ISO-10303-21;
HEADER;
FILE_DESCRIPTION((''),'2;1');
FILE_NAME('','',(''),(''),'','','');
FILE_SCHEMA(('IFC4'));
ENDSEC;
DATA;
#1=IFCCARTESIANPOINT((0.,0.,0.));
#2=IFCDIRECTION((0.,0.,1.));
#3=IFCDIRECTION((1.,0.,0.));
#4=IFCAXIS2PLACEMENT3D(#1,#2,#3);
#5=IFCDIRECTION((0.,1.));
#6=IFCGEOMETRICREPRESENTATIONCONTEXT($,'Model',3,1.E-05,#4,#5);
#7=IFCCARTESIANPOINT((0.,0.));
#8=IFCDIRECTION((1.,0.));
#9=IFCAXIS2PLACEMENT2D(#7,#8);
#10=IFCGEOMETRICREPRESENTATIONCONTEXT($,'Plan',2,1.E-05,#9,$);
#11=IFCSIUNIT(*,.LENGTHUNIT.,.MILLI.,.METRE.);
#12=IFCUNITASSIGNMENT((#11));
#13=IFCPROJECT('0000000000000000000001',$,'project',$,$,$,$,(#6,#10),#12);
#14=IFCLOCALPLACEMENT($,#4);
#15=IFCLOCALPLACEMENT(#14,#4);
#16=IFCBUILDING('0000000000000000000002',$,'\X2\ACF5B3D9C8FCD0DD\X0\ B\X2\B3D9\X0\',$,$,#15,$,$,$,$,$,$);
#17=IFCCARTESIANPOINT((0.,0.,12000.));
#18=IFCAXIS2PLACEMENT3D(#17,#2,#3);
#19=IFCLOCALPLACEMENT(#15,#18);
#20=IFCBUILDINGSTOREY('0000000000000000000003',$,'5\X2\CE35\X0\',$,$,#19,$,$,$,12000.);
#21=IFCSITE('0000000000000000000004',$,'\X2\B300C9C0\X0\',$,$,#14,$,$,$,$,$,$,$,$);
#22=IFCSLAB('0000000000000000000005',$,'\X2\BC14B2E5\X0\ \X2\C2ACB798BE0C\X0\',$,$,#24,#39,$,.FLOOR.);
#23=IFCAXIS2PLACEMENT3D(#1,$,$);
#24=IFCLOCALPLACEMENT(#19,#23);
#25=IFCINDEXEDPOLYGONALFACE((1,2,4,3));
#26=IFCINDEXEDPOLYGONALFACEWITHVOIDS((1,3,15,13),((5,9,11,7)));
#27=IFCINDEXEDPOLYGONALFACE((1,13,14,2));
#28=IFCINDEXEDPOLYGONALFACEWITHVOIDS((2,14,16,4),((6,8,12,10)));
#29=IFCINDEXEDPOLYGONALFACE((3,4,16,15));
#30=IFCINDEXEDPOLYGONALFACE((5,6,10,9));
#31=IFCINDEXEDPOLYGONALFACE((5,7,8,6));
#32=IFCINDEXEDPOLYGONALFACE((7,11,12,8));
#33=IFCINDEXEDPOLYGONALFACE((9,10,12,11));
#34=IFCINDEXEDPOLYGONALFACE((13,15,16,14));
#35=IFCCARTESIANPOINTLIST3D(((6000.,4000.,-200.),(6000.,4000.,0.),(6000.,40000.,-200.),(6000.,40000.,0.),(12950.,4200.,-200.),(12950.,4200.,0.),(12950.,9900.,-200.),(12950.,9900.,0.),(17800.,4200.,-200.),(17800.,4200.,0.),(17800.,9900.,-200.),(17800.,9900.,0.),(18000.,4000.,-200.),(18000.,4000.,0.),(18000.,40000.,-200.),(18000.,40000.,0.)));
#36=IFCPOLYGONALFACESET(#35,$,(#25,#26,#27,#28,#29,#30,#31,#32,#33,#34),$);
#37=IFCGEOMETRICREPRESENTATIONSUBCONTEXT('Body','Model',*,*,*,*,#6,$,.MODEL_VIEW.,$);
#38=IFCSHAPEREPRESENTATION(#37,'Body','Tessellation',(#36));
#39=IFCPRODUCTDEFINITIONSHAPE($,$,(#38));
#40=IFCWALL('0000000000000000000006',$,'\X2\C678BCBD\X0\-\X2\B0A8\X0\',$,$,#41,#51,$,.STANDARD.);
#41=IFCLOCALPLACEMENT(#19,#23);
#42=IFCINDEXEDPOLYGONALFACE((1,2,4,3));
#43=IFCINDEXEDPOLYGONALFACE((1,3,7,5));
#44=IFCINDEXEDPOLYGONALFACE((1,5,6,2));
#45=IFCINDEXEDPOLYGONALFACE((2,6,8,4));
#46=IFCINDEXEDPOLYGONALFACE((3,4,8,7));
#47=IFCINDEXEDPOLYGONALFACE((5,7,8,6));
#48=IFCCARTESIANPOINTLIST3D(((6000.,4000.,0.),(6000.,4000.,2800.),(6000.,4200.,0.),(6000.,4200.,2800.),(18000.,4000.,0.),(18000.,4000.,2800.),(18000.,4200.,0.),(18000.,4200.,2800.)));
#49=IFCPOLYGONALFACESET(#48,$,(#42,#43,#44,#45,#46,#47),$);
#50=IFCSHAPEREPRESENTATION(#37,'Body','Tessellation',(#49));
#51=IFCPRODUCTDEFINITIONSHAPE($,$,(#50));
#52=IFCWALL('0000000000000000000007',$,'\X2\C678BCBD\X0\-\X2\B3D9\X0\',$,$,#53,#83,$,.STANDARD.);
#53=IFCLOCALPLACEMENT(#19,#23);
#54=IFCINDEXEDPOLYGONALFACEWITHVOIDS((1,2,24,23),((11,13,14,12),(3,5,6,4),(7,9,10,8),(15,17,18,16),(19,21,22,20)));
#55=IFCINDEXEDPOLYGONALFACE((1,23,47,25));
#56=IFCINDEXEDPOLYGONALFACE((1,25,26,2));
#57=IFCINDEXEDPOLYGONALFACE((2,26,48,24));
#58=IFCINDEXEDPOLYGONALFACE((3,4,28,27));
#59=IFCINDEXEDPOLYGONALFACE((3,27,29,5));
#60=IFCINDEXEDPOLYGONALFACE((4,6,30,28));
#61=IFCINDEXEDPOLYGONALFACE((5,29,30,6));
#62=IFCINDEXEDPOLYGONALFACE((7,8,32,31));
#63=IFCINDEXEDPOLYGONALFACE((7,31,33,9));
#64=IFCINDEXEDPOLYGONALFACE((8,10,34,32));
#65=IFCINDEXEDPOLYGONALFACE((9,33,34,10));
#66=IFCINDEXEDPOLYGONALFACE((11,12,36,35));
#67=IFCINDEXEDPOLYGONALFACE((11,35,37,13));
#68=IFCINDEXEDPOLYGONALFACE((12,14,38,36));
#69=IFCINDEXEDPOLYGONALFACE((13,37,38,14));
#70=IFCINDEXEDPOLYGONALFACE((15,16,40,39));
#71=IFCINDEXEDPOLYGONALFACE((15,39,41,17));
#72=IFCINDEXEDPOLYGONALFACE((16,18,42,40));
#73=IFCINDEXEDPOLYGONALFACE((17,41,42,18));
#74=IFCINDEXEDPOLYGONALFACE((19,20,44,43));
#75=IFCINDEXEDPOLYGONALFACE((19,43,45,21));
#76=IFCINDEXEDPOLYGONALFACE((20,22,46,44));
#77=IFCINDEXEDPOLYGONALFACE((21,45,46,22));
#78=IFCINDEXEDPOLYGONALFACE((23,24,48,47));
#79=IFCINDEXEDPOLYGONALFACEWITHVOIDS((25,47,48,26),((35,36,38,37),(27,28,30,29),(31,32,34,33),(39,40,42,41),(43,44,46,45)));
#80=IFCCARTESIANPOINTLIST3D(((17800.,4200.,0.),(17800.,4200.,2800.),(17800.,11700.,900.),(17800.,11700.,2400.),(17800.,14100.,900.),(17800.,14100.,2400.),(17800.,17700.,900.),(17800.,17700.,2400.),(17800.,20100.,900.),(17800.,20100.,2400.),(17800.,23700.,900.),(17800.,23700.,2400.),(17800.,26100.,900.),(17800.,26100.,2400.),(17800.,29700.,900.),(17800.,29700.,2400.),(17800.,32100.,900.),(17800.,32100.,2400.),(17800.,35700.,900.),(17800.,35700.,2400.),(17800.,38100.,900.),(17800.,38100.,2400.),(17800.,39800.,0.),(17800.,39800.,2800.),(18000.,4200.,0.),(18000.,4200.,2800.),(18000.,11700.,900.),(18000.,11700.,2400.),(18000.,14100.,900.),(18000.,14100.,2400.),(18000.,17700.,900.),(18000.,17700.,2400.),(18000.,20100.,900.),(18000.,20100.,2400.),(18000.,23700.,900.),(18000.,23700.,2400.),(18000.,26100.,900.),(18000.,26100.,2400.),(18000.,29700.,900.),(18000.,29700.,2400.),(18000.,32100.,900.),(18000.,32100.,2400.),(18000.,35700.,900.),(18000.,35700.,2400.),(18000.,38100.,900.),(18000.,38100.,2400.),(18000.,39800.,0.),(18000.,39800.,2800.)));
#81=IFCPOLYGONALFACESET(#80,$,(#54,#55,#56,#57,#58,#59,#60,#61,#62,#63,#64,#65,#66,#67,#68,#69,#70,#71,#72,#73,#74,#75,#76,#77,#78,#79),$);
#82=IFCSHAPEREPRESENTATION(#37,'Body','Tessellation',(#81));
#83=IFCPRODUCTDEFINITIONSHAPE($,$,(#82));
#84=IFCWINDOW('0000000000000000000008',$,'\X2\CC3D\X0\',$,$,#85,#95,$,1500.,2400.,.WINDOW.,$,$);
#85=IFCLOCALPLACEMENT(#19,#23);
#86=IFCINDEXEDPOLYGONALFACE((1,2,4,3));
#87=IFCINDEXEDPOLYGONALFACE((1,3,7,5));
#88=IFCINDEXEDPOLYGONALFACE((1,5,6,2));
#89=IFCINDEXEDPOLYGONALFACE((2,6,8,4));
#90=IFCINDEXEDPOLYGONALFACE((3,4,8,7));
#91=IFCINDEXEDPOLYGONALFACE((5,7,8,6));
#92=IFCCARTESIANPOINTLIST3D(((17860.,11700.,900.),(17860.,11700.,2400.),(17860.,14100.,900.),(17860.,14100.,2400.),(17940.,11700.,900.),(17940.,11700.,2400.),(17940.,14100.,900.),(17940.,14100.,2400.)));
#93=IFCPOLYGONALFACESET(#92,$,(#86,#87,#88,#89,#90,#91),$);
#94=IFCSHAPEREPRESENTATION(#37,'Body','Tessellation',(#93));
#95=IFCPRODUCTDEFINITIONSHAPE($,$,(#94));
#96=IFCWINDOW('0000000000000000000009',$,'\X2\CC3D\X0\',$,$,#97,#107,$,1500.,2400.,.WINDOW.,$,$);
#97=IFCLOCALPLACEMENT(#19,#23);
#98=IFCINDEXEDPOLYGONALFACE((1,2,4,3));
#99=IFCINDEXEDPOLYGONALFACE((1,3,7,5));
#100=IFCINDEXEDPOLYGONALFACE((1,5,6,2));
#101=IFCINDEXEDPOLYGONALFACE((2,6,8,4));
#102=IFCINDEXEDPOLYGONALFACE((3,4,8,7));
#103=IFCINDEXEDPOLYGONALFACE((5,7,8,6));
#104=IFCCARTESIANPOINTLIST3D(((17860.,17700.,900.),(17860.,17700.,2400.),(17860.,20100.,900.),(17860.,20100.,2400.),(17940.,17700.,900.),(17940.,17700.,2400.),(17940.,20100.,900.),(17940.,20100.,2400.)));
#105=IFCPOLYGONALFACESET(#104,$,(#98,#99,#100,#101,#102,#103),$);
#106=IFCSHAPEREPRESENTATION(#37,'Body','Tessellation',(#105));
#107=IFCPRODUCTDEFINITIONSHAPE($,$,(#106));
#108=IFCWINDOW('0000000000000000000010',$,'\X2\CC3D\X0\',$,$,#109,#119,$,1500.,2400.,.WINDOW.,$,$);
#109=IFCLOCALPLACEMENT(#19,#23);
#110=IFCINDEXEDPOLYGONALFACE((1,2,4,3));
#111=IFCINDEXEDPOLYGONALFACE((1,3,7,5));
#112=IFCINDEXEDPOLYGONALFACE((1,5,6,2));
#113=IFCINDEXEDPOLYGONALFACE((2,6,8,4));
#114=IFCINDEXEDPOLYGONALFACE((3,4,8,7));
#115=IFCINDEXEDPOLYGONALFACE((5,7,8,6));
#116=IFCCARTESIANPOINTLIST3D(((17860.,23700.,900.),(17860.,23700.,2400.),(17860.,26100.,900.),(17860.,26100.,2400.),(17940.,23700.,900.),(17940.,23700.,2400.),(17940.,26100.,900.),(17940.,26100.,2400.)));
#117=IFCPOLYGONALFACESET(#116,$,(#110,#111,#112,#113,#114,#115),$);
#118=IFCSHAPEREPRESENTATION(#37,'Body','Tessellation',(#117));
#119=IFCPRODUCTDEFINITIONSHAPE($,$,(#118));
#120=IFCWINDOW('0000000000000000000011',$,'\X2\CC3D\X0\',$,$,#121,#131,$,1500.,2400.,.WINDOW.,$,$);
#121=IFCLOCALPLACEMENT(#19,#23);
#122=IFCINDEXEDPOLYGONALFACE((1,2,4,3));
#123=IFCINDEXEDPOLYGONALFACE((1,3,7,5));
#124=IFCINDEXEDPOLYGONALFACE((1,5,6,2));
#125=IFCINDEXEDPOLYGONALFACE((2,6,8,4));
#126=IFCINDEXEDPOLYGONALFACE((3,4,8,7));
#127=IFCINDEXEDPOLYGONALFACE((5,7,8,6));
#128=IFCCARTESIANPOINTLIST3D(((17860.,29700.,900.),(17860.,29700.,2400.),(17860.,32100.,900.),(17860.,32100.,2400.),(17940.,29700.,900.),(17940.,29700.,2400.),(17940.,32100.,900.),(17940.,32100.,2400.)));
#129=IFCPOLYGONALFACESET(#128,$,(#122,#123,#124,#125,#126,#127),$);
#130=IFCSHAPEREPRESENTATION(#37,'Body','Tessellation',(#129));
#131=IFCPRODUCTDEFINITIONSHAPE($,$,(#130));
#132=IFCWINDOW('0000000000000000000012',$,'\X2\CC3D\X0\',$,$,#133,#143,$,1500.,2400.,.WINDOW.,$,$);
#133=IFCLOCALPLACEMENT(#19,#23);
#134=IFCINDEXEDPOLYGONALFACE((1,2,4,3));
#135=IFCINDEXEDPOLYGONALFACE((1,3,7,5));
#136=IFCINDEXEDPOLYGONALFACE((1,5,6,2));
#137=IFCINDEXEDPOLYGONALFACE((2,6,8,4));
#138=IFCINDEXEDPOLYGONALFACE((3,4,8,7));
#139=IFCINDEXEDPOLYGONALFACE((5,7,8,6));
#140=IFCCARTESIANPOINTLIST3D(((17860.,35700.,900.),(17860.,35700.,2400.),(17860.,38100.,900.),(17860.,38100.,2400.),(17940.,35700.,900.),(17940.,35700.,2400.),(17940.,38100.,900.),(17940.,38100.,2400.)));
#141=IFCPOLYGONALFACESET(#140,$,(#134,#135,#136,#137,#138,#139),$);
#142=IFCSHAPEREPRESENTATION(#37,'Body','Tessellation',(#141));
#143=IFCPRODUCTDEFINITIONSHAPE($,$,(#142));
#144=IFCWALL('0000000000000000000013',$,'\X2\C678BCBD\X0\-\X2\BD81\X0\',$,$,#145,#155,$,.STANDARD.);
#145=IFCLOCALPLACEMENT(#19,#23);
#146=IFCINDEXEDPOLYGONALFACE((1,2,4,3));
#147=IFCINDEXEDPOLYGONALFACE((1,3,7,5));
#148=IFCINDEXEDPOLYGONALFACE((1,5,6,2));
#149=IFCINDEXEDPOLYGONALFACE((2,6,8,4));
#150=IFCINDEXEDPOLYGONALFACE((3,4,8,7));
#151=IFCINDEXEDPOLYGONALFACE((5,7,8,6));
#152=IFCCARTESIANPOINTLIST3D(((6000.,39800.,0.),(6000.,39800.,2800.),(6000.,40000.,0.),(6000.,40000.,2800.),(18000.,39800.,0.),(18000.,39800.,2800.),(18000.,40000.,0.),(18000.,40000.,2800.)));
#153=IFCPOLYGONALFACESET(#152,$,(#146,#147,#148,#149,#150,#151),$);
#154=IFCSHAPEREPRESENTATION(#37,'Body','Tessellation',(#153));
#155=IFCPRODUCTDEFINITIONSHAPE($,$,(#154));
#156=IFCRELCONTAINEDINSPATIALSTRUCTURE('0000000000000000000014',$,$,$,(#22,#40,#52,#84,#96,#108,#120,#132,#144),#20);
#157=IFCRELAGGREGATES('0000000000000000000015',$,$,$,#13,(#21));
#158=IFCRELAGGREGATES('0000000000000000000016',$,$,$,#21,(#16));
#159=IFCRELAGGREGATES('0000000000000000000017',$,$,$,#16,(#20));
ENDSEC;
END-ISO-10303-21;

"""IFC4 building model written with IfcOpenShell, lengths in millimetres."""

from ifc_helpers import new_model, si_unit, direction, frame, origin_with_axes, origin_2d_with_axis, place, context, subcontext, project, spatial, polyline, outline, extrude, element, fill, save


model = new_model("IFC4")

# Units and contexts
model_context = context("Model", 3, precision=1e-05, world=origin_with_axes(), true_north=direction((0.0, 1.0)))
plan_context = context("Plan", 2, precision=1e-05, world=origin_2d_with_axis())
body_context = subcontext(model_context, "Body", "Model", "MODEL_VIEW")
ifc_project = project(units=[si_unit("LENGTHUNIT", "METRE", prefix="MILLI")], contexts=[model_context, plan_context])

# Site, building, storey
site_placement = place(None, origin_with_axes())
site = spatial("IfcSite", under=ifc_project, at=site_placement, Name="대지")
building_placement = place(site_placement, origin_with_axes())
building = spatial("IfcBuilding", under=site, at=building_placement, Name="공동주택 B동")
storey_placement = place(building_placement, frame((0.0, 0.0, 12000.0), z_axis=(0.0, 0.0, 1.0), x_axis=(1.0, 0.0, 0.0)))
storey = spatial("IfcBuildingStorey", under=building, at=storey_placement, Name="5층", Elevation=12000.0)

# Slab
slab_placement = place(storey_placement, origin_with_axes())
element("IfcSlab", 1, at=slab_placement, inside=storey, Name="바닥 슬래브", PredefinedType="FLOOR", context=body_context, shape_type="SweptSolid", body=[
    extrude(outline(polyline([(6000.0, 4000.0), (18000.0, 4000.0), (18000.0, 40000.0), (6000.0, 40000.0), (6000.0, 4000.0)]), holes=[polyline([(12950.0, 4200.0), (17800.0, 4200.0), (17800.0, 9900.0), (12950.0, 9900.0), (12950.0, 4200.0)])]), frame((0.0, 0.0, -200.0), z_axis=(0.0, 0.0, 1.0), x_axis=(1.0, 0.0, 0.0)), (0.0, 0.0, 1.0), 200.0),
])

# Wall
wall_1_placement = place(storey_placement, origin_with_axes())
element("IfcWall", 2, at=wall_1_placement, inside=storey, Name="외벽-남", PredefinedType="STANDARD", context=body_context, shape_type="SweptSolid", body=[
    extrude(outline(polyline([(6000.0, 4200.0), (18000.0, 4200.0), (18000.0, 4000.0), (6000.0, 4000.0), (6000.0, 4200.0)])), origin_with_axes(), (0.0, 0.0, 1.0), 2800.0),
])

# Wall, openings, windows
wall_2_placement = place(storey_placement, origin_with_axes())
wall_2 = element("IfcWall", 3, at=wall_2_placement, inside=storey, Name="외벽-동", PredefinedType="STANDARD", context=body_context, shape_type="SweptSolid", body=[
    extrude(outline(polyline([(17800.0, 4200.0), (17800.0, 39800.0), (18000.0, 39800.0), (18000.0, 4200.0), (17800.0, 4200.0)])), origin_with_axes(), (0.0, 0.0, 1.0), 2800.0),
])
opening_1_placement = place(storey_placement, origin_with_axes())
opening_1 = element("IfcOpeningElement", 4, at=opening_1_placement, cuts=wall_2, PredefinedType="OPENING", context=body_context, shape_type="SweptSolid", body=[
    extrude(outline(polyline([(18050.0, 11700.0), (18050.0, 14100.0), (17750.0, 14100.0), (17750.0, 11700.0), (18050.0, 11700.0)])), frame((0.0, 0.0, 900.0), z_axis=(0.0, 0.0, 1.0), x_axis=(1.0, 0.0, 0.0)), (0.0, 0.0, 1.0), 1500.0),
])
opening_2_placement = place(storey_placement, origin_with_axes())
opening_2 = element("IfcOpeningElement", 5, at=opening_2_placement, cuts=wall_2, PredefinedType="OPENING", context=body_context, shape_type="SweptSolid", body=[
    extrude(outline(polyline([(18050.0, 17700.0), (18050.0, 20100.0), (17750.0, 20100.0), (17750.0, 17700.0), (18050.0, 17700.0)])), frame((0.0, 0.0, 900.0), z_axis=(0.0, 0.0, 1.0), x_axis=(1.0, 0.0, 0.0)), (0.0, 0.0, 1.0), 1500.0),
])
opening_3_placement = place(storey_placement, origin_with_axes())
opening_3 = element("IfcOpeningElement", 6, at=opening_3_placement, cuts=wall_2, PredefinedType="OPENING", context=body_context, shape_type="SweptSolid", body=[
    extrude(outline(polyline([(18050.0, 23700.0), (18050.0, 26100.0), (17750.0, 26100.0), (17750.0, 23700.0), (18050.0, 23700.0)])), frame((0.0, 0.0, 900.0), z_axis=(0.0, 0.0, 1.0), x_axis=(1.0, 0.0, 0.0)), (0.0, 0.0, 1.0), 1500.0),
])
opening_4_placement = place(storey_placement, origin_with_axes())
opening_4 = element("IfcOpeningElement", 7, at=opening_4_placement, cuts=wall_2, PredefinedType="OPENING", context=body_context, shape_type="SweptSolid", body=[
    extrude(outline(polyline([(18050.0, 29700.0), (18050.0, 32100.0), (17750.0, 32100.0), (17750.0, 29700.0), (18050.0, 29700.0)])), frame((0.0, 0.0, 900.0), z_axis=(0.0, 0.0, 1.0), x_axis=(1.0, 0.0, 0.0)), (0.0, 0.0, 1.0), 1500.0),
])
opening_5_placement = place(storey_placement, origin_with_axes())
opening_5 = element("IfcOpeningElement", 8, at=opening_5_placement, cuts=wall_2, PredefinedType="OPENING", context=body_context, shape_type="SweptSolid", body=[
    extrude(outline(polyline([(18050.0, 35700.0), (18050.0, 38100.0), (17750.0, 38100.0), (17750.0, 35700.0), (18050.0, 35700.0)])), frame((0.0, 0.0, 900.0), z_axis=(0.0, 0.0, 1.0), x_axis=(1.0, 0.0, 0.0)), (0.0, 0.0, 1.0), 1500.0),
])
window_1_placement = place(storey_placement, origin_with_axes())
window_1 = element("IfcWindow", 9, at=window_1_placement, inside=storey, Name="창", OverallHeight=1500.0, OverallWidth=2400.0, PredefinedType="WINDOW", context=body_context, shape_type="SweptSolid", body=[
    extrude(outline(polyline([(17940.0, 11700.0), (17940.0, 14100.0), (17860.0, 14100.0), (17860.0, 11700.0), (17940.0, 11700.0)])), frame((0.0, 0.0, 900.0), z_axis=(0.0, 0.0, 1.0), x_axis=(1.0, 0.0, 0.0)), (0.0, 0.0, 1.0), 1500.0),
])
fill(opening_1, window_1)
window_2_placement = place(storey_placement, origin_with_axes())
window_2 = element("IfcWindow", 10, at=window_2_placement, inside=storey, Name="창", OverallHeight=1500.0, OverallWidth=2400.0, PredefinedType="WINDOW", context=body_context, shape_type="SweptSolid", body=[
    extrude(outline(polyline([(17940.0, 17700.0), (17940.0, 20100.0), (17860.0, 20100.0), (17860.0, 17700.0), (17940.0, 17700.0)])), frame((0.0, 0.0, 900.0), z_axis=(0.0, 0.0, 1.0), x_axis=(1.0, 0.0, 0.0)), (0.0, 0.0, 1.0), 1500.0),
])
fill(opening_2, window_2)
window_3_placement = place(storey_placement, origin_with_axes())
window_3 = element("IfcWindow", 11, at=window_3_placement, inside=storey, Name="창", OverallHeight=1500.0, OverallWidth=2400.0, PredefinedType="WINDOW", context=body_context, shape_type="SweptSolid", body=[
    extrude(outline(polyline([(17940.0, 23700.0), (17940.0, 26100.0), (17860.0, 26100.0), (17860.0, 23700.0), (17940.0, 23700.0)])), frame((0.0, 0.0, 900.0), z_axis=(0.0, 0.0, 1.0), x_axis=(1.0, 0.0, 0.0)), (0.0, 0.0, 1.0), 1500.0),
])
fill(opening_3, window_3)
window_4_placement = place(storey_placement, origin_with_axes())
window_4 = element("IfcWindow", 12, at=window_4_placement, inside=storey, Name="창", OverallHeight=1500.0, OverallWidth=2400.0, PredefinedType="WINDOW", context=body_context, shape_type="SweptSolid", body=[
    extrude(outline(polyline([(17940.0, 29700.0), (17940.0, 32100.0), (17860.0, 32100.0), (17860.0, 29700.0), (17940.0, 29700.0)])), frame((0.0, 0.0, 900.0), z_axis=(0.0, 0.0, 1.0), x_axis=(1.0, 0.0, 0.0)), (0.0, 0.0, 1.0), 1500.0),
])
fill(opening_4, window_4)
window_5_placement = place(storey_placement, origin_with_axes())
window_5 = element("IfcWindow", 13, at=window_5_placement, inside=storey, Name="창", OverallHeight=1500.0, OverallWidth=2400.0, PredefinedType="WINDOW", context=body_context, shape_type="SweptSolid", body=[
    extrude(outline(polyline([(17940.0, 35700.0), (17940.0, 38100.0), (17860.0, 38100.0), (17860.0, 35700.0), (17940.0, 35700.0)])), frame((0.0, 0.0, 900.0), z_axis=(0.0, 0.0, 1.0), x_axis=(1.0, 0.0, 0.0)), (0.0, 0.0, 1.0), 1500.0),
])
fill(opening_5, window_5)

# Wall
wall_3_placement = place(storey_placement, origin_with_axes())
element("IfcWall", 14, at=wall_3_placement, inside=storey, Name="외벽-북", PredefinedType="STANDARD", context=body_context, shape_type="SweptSolid", body=[
    extrude(outline(polyline([(18000.0, 39800.0), (6000.0, 39800.0), (6000.0, 40000.0), (18000.0, 40000.0), (18000.0, 39800.0)])), origin_with_axes(), (0.0, 0.0, 1.0), 2800.0),
])

save(model, "model.ifc")
